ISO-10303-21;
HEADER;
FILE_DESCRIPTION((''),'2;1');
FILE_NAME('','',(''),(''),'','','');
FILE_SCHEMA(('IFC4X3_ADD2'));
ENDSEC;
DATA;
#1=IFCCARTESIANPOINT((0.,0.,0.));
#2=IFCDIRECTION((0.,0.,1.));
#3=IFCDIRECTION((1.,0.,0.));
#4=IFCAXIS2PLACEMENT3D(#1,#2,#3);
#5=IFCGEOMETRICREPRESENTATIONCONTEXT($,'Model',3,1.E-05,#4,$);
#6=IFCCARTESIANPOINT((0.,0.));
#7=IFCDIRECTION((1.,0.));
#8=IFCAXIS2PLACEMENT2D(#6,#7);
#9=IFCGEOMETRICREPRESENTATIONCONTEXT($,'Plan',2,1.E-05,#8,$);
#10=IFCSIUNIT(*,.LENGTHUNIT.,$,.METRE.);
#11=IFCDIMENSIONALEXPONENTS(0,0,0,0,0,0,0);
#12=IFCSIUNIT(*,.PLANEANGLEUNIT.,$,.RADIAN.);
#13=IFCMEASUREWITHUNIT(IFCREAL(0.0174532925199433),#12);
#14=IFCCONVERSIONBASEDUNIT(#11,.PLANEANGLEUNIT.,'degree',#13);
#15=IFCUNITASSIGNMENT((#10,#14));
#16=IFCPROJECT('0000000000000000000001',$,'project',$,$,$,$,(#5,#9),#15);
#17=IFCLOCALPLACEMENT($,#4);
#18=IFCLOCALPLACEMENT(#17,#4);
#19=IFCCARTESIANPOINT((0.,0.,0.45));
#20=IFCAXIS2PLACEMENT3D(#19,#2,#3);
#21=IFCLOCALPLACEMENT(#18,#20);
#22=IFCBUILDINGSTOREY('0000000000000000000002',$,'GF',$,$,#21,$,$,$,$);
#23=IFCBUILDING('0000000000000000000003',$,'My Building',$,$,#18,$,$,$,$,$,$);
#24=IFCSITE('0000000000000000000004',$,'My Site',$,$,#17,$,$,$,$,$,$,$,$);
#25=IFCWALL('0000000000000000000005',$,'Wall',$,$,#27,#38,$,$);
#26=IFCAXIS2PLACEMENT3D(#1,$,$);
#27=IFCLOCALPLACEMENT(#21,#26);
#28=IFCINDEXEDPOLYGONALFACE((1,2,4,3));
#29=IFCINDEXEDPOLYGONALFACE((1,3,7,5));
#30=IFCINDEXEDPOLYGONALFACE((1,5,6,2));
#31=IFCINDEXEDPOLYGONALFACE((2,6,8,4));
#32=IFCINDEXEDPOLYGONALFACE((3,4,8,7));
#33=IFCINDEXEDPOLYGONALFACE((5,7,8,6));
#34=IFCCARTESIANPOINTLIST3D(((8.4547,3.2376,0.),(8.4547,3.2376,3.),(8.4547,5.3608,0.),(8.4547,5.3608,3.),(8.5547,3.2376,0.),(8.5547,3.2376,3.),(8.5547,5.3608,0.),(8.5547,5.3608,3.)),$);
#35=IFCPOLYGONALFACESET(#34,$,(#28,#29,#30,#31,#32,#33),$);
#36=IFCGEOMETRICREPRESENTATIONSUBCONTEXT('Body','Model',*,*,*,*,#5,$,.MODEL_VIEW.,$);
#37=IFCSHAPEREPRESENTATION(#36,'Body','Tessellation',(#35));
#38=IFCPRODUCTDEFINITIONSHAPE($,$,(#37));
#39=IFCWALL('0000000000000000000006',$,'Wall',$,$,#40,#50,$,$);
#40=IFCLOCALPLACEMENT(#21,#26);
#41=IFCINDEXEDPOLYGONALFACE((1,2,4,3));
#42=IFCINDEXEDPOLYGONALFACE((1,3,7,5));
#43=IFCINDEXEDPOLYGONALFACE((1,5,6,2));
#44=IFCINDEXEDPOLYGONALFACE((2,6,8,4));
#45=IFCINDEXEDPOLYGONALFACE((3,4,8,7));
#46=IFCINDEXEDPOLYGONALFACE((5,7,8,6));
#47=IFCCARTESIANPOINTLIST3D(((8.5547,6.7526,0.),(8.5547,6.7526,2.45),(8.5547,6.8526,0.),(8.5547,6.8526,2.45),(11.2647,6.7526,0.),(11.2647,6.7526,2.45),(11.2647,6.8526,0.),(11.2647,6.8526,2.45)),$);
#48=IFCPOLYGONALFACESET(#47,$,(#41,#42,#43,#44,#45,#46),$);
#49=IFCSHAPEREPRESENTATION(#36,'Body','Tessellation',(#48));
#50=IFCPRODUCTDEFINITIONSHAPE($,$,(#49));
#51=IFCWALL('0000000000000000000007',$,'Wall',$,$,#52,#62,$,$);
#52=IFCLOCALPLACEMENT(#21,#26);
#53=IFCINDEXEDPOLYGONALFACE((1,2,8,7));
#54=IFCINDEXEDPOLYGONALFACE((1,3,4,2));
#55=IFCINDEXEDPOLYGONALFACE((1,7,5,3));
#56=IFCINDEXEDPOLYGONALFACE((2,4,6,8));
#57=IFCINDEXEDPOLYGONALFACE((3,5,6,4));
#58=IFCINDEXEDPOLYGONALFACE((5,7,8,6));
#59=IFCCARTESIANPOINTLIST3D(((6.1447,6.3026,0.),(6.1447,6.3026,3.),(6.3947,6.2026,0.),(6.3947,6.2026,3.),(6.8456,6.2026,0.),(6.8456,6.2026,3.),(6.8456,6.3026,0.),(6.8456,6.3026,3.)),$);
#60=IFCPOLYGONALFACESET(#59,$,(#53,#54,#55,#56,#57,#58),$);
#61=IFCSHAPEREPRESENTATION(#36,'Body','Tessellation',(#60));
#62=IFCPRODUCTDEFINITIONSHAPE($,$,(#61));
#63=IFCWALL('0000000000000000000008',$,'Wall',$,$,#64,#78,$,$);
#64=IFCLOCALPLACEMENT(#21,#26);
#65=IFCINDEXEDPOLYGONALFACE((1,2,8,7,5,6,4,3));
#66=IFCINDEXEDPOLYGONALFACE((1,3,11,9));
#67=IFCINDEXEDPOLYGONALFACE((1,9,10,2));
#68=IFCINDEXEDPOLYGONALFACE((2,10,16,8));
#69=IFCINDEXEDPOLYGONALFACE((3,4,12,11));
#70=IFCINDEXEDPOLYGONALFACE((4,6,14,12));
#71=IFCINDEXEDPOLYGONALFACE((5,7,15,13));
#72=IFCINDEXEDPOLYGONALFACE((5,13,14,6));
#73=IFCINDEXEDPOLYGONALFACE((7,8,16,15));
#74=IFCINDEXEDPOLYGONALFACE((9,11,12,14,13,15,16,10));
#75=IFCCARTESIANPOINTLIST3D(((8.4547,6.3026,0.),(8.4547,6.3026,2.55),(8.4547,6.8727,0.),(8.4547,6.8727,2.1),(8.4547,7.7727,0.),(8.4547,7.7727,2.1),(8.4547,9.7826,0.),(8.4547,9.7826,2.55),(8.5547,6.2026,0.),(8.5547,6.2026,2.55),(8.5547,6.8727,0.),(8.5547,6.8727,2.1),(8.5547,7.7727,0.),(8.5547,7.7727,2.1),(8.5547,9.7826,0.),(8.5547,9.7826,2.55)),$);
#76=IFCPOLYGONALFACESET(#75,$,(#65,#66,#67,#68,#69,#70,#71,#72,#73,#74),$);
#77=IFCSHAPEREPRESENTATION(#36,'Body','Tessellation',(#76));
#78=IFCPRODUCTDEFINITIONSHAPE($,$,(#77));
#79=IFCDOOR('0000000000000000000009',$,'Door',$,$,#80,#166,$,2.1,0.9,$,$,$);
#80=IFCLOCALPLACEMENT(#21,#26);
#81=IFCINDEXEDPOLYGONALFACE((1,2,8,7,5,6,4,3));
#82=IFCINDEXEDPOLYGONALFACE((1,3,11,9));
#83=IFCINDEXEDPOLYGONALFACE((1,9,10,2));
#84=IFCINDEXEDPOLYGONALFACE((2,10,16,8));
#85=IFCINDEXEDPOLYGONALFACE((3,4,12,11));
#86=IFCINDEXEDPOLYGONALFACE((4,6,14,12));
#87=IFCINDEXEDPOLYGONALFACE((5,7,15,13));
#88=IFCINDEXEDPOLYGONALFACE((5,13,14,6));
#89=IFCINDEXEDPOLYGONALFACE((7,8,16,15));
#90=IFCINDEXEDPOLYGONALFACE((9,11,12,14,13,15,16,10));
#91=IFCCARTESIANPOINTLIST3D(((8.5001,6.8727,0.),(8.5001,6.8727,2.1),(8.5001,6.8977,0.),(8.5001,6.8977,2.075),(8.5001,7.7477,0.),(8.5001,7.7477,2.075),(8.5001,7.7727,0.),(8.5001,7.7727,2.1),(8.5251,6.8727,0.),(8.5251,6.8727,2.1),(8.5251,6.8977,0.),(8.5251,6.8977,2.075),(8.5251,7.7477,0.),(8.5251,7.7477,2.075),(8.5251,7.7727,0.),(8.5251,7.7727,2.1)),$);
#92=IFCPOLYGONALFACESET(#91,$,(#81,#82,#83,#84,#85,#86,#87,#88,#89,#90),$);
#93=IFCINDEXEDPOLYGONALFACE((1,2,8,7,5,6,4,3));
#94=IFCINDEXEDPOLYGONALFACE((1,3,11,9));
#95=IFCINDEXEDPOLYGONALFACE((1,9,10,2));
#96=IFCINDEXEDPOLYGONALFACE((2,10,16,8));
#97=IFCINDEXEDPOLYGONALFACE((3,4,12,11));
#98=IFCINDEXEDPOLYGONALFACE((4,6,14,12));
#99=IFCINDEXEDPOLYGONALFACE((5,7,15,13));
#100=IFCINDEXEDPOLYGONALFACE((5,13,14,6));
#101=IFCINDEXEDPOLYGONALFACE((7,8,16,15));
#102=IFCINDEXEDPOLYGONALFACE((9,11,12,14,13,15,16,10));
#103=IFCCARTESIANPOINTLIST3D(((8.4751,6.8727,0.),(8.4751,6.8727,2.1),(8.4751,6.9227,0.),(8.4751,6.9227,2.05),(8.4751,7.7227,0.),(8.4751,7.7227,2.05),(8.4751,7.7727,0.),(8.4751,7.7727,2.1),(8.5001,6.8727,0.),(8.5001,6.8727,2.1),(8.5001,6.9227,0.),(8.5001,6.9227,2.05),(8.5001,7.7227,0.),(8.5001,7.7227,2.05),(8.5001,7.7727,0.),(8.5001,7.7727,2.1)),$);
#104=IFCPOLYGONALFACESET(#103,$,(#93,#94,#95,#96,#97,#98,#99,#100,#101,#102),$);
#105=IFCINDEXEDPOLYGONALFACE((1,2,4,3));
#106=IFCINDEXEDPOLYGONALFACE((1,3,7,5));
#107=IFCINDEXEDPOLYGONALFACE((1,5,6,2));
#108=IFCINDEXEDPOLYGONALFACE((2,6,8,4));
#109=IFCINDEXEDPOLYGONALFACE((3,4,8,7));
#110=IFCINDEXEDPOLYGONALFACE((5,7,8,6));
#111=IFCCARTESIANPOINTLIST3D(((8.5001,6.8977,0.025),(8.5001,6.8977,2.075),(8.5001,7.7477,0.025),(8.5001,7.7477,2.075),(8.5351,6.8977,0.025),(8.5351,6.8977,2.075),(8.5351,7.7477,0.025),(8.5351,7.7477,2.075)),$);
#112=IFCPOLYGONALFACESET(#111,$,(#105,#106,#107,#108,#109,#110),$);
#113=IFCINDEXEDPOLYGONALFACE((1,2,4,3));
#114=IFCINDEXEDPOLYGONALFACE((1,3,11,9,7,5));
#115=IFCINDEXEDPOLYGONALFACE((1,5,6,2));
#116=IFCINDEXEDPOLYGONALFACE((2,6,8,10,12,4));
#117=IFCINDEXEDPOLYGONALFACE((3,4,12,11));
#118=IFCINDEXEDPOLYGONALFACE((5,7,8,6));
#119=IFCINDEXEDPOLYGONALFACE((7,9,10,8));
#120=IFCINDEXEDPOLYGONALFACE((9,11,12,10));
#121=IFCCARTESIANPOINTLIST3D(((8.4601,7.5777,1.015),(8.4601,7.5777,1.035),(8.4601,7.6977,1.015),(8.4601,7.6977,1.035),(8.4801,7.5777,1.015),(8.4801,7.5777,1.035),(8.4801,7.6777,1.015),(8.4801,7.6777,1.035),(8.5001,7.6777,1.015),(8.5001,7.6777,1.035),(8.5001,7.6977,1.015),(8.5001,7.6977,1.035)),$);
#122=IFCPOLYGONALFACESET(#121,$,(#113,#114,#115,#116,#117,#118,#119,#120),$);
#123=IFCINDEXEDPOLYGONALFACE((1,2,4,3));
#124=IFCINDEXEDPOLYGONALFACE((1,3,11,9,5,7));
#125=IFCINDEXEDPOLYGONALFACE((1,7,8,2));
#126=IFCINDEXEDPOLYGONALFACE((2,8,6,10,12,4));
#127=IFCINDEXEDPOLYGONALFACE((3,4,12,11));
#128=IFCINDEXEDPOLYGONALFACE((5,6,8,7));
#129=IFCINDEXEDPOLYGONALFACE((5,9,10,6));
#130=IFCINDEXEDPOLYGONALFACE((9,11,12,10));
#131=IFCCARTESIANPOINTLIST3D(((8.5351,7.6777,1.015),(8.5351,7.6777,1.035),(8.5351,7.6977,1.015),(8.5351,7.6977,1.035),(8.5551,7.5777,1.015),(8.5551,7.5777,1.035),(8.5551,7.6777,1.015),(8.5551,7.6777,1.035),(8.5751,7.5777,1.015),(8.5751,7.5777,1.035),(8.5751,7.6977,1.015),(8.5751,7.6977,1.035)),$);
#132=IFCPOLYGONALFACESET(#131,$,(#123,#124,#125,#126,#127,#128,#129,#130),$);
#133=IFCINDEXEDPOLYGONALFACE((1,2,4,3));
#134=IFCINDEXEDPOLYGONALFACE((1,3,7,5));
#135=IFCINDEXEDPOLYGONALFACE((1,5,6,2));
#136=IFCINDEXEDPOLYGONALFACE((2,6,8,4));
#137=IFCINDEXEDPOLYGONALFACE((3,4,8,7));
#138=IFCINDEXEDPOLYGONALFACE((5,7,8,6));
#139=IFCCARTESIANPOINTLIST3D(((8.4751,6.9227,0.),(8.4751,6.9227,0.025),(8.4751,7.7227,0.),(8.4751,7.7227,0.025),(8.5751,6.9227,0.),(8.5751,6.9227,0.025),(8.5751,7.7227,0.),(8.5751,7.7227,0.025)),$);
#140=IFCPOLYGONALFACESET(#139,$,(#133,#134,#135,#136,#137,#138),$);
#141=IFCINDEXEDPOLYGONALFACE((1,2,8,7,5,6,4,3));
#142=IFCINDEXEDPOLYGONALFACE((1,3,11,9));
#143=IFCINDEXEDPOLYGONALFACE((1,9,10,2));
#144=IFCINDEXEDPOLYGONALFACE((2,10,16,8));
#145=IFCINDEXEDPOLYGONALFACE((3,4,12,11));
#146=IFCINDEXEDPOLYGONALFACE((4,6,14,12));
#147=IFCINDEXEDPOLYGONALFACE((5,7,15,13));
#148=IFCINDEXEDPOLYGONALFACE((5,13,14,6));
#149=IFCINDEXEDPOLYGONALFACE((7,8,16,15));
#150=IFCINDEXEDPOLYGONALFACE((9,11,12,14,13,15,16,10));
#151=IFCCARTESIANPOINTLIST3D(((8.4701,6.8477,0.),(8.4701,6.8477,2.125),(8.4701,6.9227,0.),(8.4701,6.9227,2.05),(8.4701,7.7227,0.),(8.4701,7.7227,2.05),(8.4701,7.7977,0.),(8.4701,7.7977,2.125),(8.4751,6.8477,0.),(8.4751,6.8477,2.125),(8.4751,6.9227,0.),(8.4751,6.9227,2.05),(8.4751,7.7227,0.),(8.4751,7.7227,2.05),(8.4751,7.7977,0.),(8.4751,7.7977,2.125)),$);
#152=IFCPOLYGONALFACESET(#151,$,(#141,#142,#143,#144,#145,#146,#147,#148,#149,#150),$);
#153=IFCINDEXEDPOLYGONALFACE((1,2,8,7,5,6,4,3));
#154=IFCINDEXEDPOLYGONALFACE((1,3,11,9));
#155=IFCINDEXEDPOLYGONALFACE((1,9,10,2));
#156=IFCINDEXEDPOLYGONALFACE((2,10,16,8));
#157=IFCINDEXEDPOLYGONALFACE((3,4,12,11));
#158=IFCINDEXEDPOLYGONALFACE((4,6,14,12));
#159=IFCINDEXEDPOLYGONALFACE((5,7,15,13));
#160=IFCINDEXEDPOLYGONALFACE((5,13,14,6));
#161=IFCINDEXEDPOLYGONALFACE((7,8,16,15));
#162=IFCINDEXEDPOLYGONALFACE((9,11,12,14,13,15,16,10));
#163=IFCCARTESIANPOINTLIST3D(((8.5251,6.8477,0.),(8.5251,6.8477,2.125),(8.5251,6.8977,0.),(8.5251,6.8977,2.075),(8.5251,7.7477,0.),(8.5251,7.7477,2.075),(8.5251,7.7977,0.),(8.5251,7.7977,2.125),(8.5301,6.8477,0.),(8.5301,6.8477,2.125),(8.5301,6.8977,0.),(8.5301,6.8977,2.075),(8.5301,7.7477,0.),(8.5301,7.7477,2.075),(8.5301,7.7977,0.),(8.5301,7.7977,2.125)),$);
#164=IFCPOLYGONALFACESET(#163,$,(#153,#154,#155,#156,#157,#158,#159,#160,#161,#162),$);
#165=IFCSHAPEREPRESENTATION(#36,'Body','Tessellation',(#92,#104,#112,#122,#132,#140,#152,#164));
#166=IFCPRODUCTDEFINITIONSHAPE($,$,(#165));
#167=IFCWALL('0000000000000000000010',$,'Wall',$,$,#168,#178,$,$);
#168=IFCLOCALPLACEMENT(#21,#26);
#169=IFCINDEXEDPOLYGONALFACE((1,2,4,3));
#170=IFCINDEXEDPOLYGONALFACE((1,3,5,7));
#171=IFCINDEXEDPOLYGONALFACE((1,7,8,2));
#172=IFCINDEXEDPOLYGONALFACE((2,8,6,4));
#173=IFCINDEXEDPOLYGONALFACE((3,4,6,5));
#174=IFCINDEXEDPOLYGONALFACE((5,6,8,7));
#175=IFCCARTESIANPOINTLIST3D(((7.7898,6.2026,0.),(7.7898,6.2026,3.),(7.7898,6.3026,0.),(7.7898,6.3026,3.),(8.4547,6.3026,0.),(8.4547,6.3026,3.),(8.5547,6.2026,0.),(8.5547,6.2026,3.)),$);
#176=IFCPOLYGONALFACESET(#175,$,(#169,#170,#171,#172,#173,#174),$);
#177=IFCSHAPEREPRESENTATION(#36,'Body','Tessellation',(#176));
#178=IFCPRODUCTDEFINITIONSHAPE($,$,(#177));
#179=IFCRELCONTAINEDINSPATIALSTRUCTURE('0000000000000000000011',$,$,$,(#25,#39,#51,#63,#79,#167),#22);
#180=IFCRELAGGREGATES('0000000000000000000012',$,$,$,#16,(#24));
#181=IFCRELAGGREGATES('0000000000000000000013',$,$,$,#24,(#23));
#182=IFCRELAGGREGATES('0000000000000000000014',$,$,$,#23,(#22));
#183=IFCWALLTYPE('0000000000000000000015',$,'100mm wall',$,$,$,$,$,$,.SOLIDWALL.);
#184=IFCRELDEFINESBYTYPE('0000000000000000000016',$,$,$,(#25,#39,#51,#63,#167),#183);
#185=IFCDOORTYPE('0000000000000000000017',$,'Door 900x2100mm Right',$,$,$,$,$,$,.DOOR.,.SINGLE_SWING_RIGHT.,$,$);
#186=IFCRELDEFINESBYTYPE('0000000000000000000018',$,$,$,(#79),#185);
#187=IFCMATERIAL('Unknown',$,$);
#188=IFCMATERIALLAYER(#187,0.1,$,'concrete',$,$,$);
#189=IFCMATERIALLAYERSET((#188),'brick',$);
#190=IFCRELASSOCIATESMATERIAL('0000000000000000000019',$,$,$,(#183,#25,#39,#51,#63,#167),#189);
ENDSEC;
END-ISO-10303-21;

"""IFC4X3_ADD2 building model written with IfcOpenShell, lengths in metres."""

from ifc_helpers import new_model, entity, si_unit, converted_unit, frame, origin_with_axes, origin_2d_with_axis, place, context, subcontext, project, spatial, line, indexed_curve, outline, extrude, shape, source, transform, mapped, material, layer, layer_set, layer_usage, type_object, type_shapes, element, fill, save


model = new_model("IFC4X3_ADD2")

# Units and contexts
model_context = context("Model", 3, precision=1e-05, world=origin_with_axes())
plan_context = context("Plan", 2, precision=1e-05, world=origin_2d_with_axis())
body_context_1 = subcontext(model_context, "Body", "Model", "MODEL_VIEW")
body_context_2 = subcontext(plan_context, "Body", "Plan", "PLAN_VIEW")
ifc_project = project(units=[si_unit("LENGTHUNIT", "METRE"), converted_unit("PLANEANGLEUNIT", "degree", entity("IfcReal", 0.0174532925199433), si_unit("PLANEANGLEUNIT", "RADIAN"), dimensions=[0, 0, 0, 0, 0, 0, 0])], contexts=[model_context, plan_context])

# Site, building, storey
site_placement = place(None, origin_with_axes())
site = spatial("IfcSite", under=ifc_project, at=site_placement, Name="My Site")
building_placement = place(site_placement, origin_with_axes())
building = spatial("IfcBuilding", under=site, at=building_placement, Name="My Building")
storey_placement = place(building_placement, frame((0.0, 0.0, 0.45), z_axis=(0.0, 0.0, 1.0), x_axis=(1.0, 0.0, 0.0)))
storey = spatial("IfcBuildingStorey", under=building, at=storey_placement, Name="GF")

# Shared definitions
ifc_material_1 = material(Name="Unknown")

# Walls
ifc_layer_1 = layer(ifc_material_1, 0.1, Name="concrete")
ifc_layer_set_1 = layer_set([ifc_layer_1], Name="brick")
ifc_layer_usage_1 = layer_usage(ifc_layer_set_1, "AXIS2", "POSITIVE", 0.0)
wall_type_1 = type_object("IfcWallType", Name="100mm wall", PredefinedType="SOLIDWALL", material=ifc_layer_set_1)
wall_1_placement = place(storey_placement, frame((8.5547, 3.2376, 0.0), z_axis=(0.0, 0.0, 1.0), x_axis=(0.0, 1.0, 0.0)))
element("IfcWall", 1, at=wall_1_placement, inside=storey, type_object=wall_type_1, material=ifc_layer_usage_1, Name="Wall", context=body_context_1, shape_type="SweptSolid", body=[
    extrude(outline(indexed_curve([(0.0, 0.0), (0.0, 0.1), (2.1232, 0.1), (2.1232, 0.0)], segments=[line(1, 2, 3, 4, 1)])), origin_with_axes(), (0.0, 0.0, 1.0), 3.0),
])
ifc_layer_usage_2 = layer_usage(ifc_layer_set_1, "AXIS2", "POSITIVE", 0.0)
wall_2_placement = place(storey_placement, frame((8.5547, 6.7526, 0.0), z_axis=(0.0, 0.0, 1.0), x_axis=(1.0, 0.0, 0.0)))
element("IfcWall", 2, at=wall_2_placement, inside=storey, type_object=wall_type_1, material=ifc_layer_usage_2, Name="Wall", context=body_context_1, shape_type="SweptSolid", body=[
    extrude(outline(indexed_curve([(0.0, 0.0), (0.0, 0.1), (2.71, 0.1), (2.71, 0.0)], segments=[line(1, 2, 3, 4, 1)])), origin_with_axes(), (0.0, 0.0, 1.0), 2.45),
])
ifc_layer_usage_3 = layer_usage(ifc_layer_set_1, "AXIS2", "POSITIVE", 0.0)
wall_3_placement = place(storey_placement, frame((6.3947, 6.2026, 0.0), z_axis=(0.0, 0.0, 1.0), x_axis=(1.0, 0.0, 0.0)))
element("IfcWall", 3, at=wall_3_placement, inside=storey, type_object=wall_type_1, material=ifc_layer_usage_3, Name="Wall", context=body_context_1, shape_type="SweptSolid", body=[
    extrude(outline(indexed_curve([(0.0, 0.0), (-0.25, 0.1), (0.451, 0.1), (0.451, 0.0)], segments=[line(1, 2, 3, 4, 1)])), origin_with_axes(), (0.0, 0.0, 1.0), 3.0),
])

# Wall, opening, door
ifc_layer_usage_4 = layer_usage(ifc_layer_set_1, "AXIS2", "POSITIVE", 0.0)
wall_4_placement = place(storey_placement, frame((8.5547, 6.2026, 0.0), z_axis=(0.0, 0.0, 1.0), x_axis=(0.0, 1.0, 0.0)))
wall_4 = element("IfcWall", 4, at=wall_4_placement, inside=storey, type_object=wall_type_1, material=ifc_layer_usage_4, Name="Wall", context=body_context_1, shape_type="SweptSolid", body=[
    extrude(outline(indexed_curve([(0.0, 0.0), (0.1, 0.1), (3.58, 0.1), (3.58, 0.0)], segments=[line(1, 2, 3, 4, 1)])), origin_with_axes(), (0.0, 0.0, 1.0), 2.55),
])
shared_shape_1 = source(origin_with_axes(), body_context_1, "Body", "SolidModel", [
    extrude(outline(indexed_curve([(0.0, 0.0), (0.9, 0.0), (0.9, 2.1), (0.0, 2.1)], segments=[line(1, 2, 3, 4, 1)])), frame((0.0, -0.6, 0.0), z_axis=(0.0, -1.0, 0.0), x_axis=(1.0, 0.0, 0.0)), (0.0, 0.0, -1.0), 1.2),
])
opening_1_placement = place(wall_4_placement, frame((1.5702, 0.0796, 0.0), z_axis=(0.0, 0.0, 1.0), x_axis=(-1.0, 0.0, 0.0)))
opening_1 = element("IfcOpeningElement", 5, at=opening_1_placement, cuts=wall_4, PredefinedType="OPENING", context=body_context_1, shape_type="MappedRepresentation", body=[
    mapped(shared_shape_1, transform((0.0, 0.0, 0.0), x_axis=(1.0, 0.0, 0.0), y_axis=(0.0, 1.0, 0.0), z_axis=(0.0, 0.0, 1.0), scale=1.0)),
])
door_type_1 = type_object("IfcDoorType", Name="Door 900x2100mm Right", OperationType="SINGLE_SWING_RIGHT", PredefinedType="DOOR")
shared_shape_2 = source(origin_with_axes(), body_context_1, "Body", "SweptSolid", [
    extrude(outline(indexed_curve([(0.0, 0.0), (0.0, 2.1), (0.9, 2.1), (0.9, 0.0), (0.875, 0.0), (0.875, 2.075), (0.025, 2.075), (0.025, 0.0)], segments=[line(1, 2, 3, 4, 5, 6, 7, 8, 1)])), frame((0.0, 0.025, 0.0), z_axis=(0.0, -1.0, 0.0), x_axis=(1.0, 0.0, 0.0)), (0.0, 0.0, -1.0), 0.025),
    extrude(outline(indexed_curve([(0.0, 0.0), (0.0, 2.1), (0.9, 2.1), (0.9, 0.0), (0.85, 0.0), (0.85, 2.05), (0.05, 2.05), (0.05, 0.0)], segments=[line(1, 2, 3, 4, 5, 6, 7, 8, 1)])), frame((0.0, 0.0, 0.0), z_axis=(0.0, -1.0, 0.0), x_axis=(1.0, 0.0, 0.0)), (0.0, 0.0, -1.0), 0.025),
    extrude(outline(indexed_curve([(0.0, 0.0), (0.85, 0.0), (0.85, 0.035), (0.0, 0.035)], segments=[line(1, 2, 3, 4, 1)])), frame((0.025, 0.025, 0.025), z_axis=(0.0, 0.0, 1.0), x_axis=(1.0, 0.0, 0.0)), (0.0, 0.0, 1.0), 2.05),
    extrude(outline(indexed_curve([(0.0, 0.0), (0.0, -0.04), (0.12, -0.04), (0.12, -0.02), (0.02, -0.02), (0.02, 0.0)], segments=[line(1, 2, 3, 4, 5, 6, 1)])), frame((0.075, 0.025, 1.015), z_axis=(0.0, 0.0, 1.0), x_axis=(1.0, 0.0, 0.0)), (0.0, 0.0, 1.0), 0.02),
    extrude(outline(indexed_curve([(0.0, 0.0), (0.0, 0.04), (0.12, 0.04), (0.12, 0.02), (0.02, 0.02), (0.02, 0.0)], segments=[line(1, 2, 3, 4, 5, 6, 1)])), frame((0.075, 0.06, 1.015), z_axis=(0.0, 0.0, 1.0), x_axis=(1.0, 0.0, 0.0)), (0.0, 0.0, 1.0), 0.02),
    extrude(outline(indexed_curve([(0.0, 0.0), (0.8, 0.0), (0.8, 0.1), (0.0, 0.1)], segments=[line(1, 2, 3, 4, 1)])), frame((0.05, 0.0, 0.0), z_axis=(0.0, 0.0, 1.0), x_axis=(1.0, 0.0, 0.0)), (0.0, 0.0, 1.0), 0.025),
    extrude(outline(indexed_curve([(0.0, 0.0), (0.0, 2.125), (0.95, 2.125), (0.95, 0.0), (0.875, 0.0), (0.875, 2.05), (0.075, 2.05), (0.075, 0.0)], segments=[line(1, 2, 3, 4, 5, 6, 7, 8, 1)])), frame((-0.025, -0.005, 0.0), z_axis=(0.0, -1.0, 0.0), x_axis=(1.0, 0.0, 0.0)), (0.0, 0.0, -1.0), 0.005),
    extrude(outline(indexed_curve([(0.0, 0.0), (0.0, 2.125), (0.95, 2.125), (0.95, 0.0), (0.9, 0.0), (0.9, 2.075), (0.05, 2.075), (0.05, 0.0)], segments=[line(1, 2, 3, 4, 5, 6, 7, 8, 1)])), frame((-0.025, 0.05, 0.0), z_axis=(0.0, -1.0, 0.0), x_axis=(1.0, 0.0, 0.0)), (0.0, 0.0, -1.0), 0.005),
])
shared_shape_3 = source(origin_with_axes(), body_context_2, "Body", "Curve2D", [
    entity("IfcIndexedPolyCurve", entity("IfcCartesianPointList2D", [[0.0, 0.0], [0.0, 0.05], [0.025, 0.05], [0.025, 0.025], [0.05, 0.025], [0.05, 0.0]]), [entity("IfcLineIndex", [1, 2, 3, 4, 5, 6, 1])]),
    entity("IfcIndexedPolyCurve", entity("IfcCartesianPointList2D", [[0.9, 0.0], [0.9, 0.05], [0.875, 0.05], [0.875, 0.025], [0.85, 0.025], [0.85, 0.0]]), [entity("IfcLineIndex", [1, 2, 3, 4, 5, 6, 1])]),
    entity("IfcTrimmedCurve", entity("IfcEllipse", entity("IfcAxis2Placement2D", entity("IfcCartesianPoint", [0.84, 0.05]), entity("IfcDirection", [1.0, 0.0])), 0.815, 0.85), [entity("IfcCartesianPoint", [0.84, 0.9])], [entity("IfcCartesianPoint", [0.025, 0.05])], True, "CARTESIAN"),
    entity("IfcIndexedPolyCurve", entity("IfcCartesianPointList2D", [[0.875, 0.05], [0.84, 0.05], [0.84, 0.9], [0.875, 0.9]]), [entity("IfcLineIndex", [1, 2, 3, 4, 1])]),
])
type_shapes(door_type_1, [shared_shape_2, shared_shape_3])
door_1_placement = place(opening_1_placement, frame((0.0, 0.0, 0.0), z_axis=(0.0, 0.0, 1.0), x_axis=(1.0, 0.0, 0.0)))
door_1 = element("IfcDoor", 6, at=door_1_placement, inside=storey, type_object=door_type_1, Name="Door", OverallHeight=2.1, OverallWidth=0.9, shapes=[
    shape(body_context_1, "Body", "MappedRepresentation", [mapped(shared_shape_2, transform((0.0, 0.0, 0.0), x_axis=(1.0, 0.0, 0.0), y_axis=(0.0, 1.0, 0.0), z_axis=(0.0, 0.0, 1.0), scale=1.0))]),
    shape(body_context_2, "Body", "MappedRepresentation", [mapped(shared_shape_3, transform((0.0, 0.0, 0.0), x_axis=(1.0, 0.0, 0.0), y_axis=(0.0, 1.0, 0.0), z_axis=(0.0, 0.0, 1.0), scale=1.0))]),
])
fill(opening_1, door_1)

# Wall
ifc_layer_usage_5 = layer_usage(ifc_layer_set_1, "AXIS2", "POSITIVE", 0.0)
wall_5_placement = place(storey_placement, frame((7.7898, 6.2026, 0.0), z_axis=(0.0, 0.0, 1.0), x_axis=(1.0, 0.0, 0.0)))
element("IfcWall", 7, at=wall_5_placement, inside=storey, type_object=wall_type_1, material=ifc_layer_usage_5, Name="Wall", context=body_context_1, shape_type="SweptSolid", body=[
    extrude(outline(indexed_curve([(0.0, 0.0), (0.0, 0.1), (0.6649, 0.1), (0.7649, 0.0)], segments=[line(1, 2, 3, 4, 1)])), origin_with_axes(), (0.0, 0.0, 1.0), 3.0),
])

save(model, "model.ifc")
